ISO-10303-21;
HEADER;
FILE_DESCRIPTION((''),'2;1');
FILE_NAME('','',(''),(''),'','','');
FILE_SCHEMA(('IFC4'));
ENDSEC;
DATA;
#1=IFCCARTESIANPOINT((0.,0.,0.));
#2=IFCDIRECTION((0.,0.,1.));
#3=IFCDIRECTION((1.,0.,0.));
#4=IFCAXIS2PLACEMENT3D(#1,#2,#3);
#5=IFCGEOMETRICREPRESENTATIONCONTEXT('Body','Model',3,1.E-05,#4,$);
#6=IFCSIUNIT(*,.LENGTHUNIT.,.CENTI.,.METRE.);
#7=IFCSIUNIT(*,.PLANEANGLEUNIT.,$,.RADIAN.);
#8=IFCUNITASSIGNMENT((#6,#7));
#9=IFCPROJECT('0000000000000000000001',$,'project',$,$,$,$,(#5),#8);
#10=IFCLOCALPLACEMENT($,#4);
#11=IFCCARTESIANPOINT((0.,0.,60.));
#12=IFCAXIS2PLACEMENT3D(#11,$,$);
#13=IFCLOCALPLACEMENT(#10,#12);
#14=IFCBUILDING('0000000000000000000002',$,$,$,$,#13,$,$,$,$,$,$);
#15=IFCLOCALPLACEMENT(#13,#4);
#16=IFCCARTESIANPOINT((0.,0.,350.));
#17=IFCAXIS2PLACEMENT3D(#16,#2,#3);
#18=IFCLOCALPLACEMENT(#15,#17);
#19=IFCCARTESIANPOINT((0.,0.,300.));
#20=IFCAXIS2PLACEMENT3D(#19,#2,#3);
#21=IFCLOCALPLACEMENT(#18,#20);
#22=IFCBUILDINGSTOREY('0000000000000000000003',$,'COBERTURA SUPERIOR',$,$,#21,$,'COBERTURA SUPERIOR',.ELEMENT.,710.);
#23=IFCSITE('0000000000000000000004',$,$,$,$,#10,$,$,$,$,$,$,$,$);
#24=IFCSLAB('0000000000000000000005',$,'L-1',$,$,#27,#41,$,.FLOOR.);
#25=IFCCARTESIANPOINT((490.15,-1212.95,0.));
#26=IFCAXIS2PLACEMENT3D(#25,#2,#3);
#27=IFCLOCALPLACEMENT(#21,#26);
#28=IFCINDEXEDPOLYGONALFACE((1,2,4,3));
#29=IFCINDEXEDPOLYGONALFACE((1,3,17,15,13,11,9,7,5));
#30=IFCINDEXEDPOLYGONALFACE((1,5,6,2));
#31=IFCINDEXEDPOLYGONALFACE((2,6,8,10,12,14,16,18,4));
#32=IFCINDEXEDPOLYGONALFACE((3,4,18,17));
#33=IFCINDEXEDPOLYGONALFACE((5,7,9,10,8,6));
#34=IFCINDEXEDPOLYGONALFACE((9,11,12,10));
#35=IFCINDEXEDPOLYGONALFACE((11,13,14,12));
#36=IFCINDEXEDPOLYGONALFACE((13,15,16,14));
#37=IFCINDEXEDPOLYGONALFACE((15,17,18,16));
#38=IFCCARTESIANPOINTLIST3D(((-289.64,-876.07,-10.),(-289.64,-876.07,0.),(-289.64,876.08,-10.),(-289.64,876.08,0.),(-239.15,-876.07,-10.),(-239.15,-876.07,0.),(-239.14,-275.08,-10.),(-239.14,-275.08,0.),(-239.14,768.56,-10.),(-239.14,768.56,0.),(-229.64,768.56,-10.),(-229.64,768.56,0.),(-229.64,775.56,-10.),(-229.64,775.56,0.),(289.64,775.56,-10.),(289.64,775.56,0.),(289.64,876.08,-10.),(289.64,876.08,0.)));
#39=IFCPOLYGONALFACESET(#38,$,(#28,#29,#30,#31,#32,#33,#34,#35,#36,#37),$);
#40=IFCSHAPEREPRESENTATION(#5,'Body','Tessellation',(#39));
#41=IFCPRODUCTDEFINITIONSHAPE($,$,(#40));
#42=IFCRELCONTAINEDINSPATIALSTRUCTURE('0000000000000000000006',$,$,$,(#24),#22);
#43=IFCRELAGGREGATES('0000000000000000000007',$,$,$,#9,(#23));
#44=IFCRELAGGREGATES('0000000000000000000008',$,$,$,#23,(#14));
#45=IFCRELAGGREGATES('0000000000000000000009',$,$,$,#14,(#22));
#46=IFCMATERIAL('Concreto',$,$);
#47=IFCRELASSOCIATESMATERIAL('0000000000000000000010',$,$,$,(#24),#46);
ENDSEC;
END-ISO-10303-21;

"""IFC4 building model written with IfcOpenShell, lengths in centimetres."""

from ifc_helpers import new_model, si_unit, frame, origin_with_axes, place, context, project, spatial, polyline, outline, extrude, material, element, save


model = new_model("IFC4")

# Units and contexts
model_context = context("Model", 3, precision=1e-05, world=origin_with_axes(), identifier="Body")
ifc_project = project(units=[si_unit("LENGTHUNIT", "METRE", prefix="CENTI"), si_unit("PLANEANGLEUNIT", "RADIAN")], contexts=[model_context])

# Site, building, storey
site_placement = place(None, origin_with_axes())
site = spatial("IfcSite", under=ifc_project, at=site_placement)
building_placement = place(site_placement, frame((0.0, 0.0, 60.0)))
building = spatial("IfcBuilding", under=site, at=building_placement)
placement_1 = place(building_placement, origin_with_axes())
placement_2 = place(placement_1, frame((0.0, 0.0, 350.0), z_axis=(0.0, 0.0, 1.0), x_axis=(1.0, 0.0, 0.0)))
storey_placement = place(placement_2, frame((0.0, 0.0, 300.0), z_axis=(0.0, 0.0, 1.0), x_axis=(1.0, 0.0, 0.0)))
storey = spatial("IfcBuildingStorey", under=building, at=storey_placement, Name="COBERTURA SUPERIOR", LongName="COBERTURA SUPERIOR", CompositionType="ELEMENT", Elevation=710.0)

# Shared definitions
ifc_material = material(Name="Concreto")

# Slab
slab_1_placement = place(storey_placement, frame((490.15, -1212.95, 0.0), z_axis=(0.0, 0.0, 1.0), x_axis=(1.0, 0.0, 0.0)))
element("IfcSlab", 1, at=slab_1_placement, inside=storey, material=ifc_material, Name="L-1", PredefinedType="FLOOR", context=model_context, shape_type="SolidModel", body=[
    extrude(outline(polyline([(-239.16, -876.07), (-239.15, -275.07), (-239.15, 768.57), (-229.65, 768.57), (-229.65, 775.57), (289.64, 775.57), (289.64, 876.08), (-289.64, 876.08), (-289.64, -876.08), (-239.16, -876.07), (-239.16, -876.07)])), frame((0.0, 0.0, -10.0), z_axis=(0.0, 0.0, 1.0), x_axis=(1.0, 0.0, 0.0)), (0.0, 0.0, 1.0), 10.0),
])

save(model, "model.ifc")
